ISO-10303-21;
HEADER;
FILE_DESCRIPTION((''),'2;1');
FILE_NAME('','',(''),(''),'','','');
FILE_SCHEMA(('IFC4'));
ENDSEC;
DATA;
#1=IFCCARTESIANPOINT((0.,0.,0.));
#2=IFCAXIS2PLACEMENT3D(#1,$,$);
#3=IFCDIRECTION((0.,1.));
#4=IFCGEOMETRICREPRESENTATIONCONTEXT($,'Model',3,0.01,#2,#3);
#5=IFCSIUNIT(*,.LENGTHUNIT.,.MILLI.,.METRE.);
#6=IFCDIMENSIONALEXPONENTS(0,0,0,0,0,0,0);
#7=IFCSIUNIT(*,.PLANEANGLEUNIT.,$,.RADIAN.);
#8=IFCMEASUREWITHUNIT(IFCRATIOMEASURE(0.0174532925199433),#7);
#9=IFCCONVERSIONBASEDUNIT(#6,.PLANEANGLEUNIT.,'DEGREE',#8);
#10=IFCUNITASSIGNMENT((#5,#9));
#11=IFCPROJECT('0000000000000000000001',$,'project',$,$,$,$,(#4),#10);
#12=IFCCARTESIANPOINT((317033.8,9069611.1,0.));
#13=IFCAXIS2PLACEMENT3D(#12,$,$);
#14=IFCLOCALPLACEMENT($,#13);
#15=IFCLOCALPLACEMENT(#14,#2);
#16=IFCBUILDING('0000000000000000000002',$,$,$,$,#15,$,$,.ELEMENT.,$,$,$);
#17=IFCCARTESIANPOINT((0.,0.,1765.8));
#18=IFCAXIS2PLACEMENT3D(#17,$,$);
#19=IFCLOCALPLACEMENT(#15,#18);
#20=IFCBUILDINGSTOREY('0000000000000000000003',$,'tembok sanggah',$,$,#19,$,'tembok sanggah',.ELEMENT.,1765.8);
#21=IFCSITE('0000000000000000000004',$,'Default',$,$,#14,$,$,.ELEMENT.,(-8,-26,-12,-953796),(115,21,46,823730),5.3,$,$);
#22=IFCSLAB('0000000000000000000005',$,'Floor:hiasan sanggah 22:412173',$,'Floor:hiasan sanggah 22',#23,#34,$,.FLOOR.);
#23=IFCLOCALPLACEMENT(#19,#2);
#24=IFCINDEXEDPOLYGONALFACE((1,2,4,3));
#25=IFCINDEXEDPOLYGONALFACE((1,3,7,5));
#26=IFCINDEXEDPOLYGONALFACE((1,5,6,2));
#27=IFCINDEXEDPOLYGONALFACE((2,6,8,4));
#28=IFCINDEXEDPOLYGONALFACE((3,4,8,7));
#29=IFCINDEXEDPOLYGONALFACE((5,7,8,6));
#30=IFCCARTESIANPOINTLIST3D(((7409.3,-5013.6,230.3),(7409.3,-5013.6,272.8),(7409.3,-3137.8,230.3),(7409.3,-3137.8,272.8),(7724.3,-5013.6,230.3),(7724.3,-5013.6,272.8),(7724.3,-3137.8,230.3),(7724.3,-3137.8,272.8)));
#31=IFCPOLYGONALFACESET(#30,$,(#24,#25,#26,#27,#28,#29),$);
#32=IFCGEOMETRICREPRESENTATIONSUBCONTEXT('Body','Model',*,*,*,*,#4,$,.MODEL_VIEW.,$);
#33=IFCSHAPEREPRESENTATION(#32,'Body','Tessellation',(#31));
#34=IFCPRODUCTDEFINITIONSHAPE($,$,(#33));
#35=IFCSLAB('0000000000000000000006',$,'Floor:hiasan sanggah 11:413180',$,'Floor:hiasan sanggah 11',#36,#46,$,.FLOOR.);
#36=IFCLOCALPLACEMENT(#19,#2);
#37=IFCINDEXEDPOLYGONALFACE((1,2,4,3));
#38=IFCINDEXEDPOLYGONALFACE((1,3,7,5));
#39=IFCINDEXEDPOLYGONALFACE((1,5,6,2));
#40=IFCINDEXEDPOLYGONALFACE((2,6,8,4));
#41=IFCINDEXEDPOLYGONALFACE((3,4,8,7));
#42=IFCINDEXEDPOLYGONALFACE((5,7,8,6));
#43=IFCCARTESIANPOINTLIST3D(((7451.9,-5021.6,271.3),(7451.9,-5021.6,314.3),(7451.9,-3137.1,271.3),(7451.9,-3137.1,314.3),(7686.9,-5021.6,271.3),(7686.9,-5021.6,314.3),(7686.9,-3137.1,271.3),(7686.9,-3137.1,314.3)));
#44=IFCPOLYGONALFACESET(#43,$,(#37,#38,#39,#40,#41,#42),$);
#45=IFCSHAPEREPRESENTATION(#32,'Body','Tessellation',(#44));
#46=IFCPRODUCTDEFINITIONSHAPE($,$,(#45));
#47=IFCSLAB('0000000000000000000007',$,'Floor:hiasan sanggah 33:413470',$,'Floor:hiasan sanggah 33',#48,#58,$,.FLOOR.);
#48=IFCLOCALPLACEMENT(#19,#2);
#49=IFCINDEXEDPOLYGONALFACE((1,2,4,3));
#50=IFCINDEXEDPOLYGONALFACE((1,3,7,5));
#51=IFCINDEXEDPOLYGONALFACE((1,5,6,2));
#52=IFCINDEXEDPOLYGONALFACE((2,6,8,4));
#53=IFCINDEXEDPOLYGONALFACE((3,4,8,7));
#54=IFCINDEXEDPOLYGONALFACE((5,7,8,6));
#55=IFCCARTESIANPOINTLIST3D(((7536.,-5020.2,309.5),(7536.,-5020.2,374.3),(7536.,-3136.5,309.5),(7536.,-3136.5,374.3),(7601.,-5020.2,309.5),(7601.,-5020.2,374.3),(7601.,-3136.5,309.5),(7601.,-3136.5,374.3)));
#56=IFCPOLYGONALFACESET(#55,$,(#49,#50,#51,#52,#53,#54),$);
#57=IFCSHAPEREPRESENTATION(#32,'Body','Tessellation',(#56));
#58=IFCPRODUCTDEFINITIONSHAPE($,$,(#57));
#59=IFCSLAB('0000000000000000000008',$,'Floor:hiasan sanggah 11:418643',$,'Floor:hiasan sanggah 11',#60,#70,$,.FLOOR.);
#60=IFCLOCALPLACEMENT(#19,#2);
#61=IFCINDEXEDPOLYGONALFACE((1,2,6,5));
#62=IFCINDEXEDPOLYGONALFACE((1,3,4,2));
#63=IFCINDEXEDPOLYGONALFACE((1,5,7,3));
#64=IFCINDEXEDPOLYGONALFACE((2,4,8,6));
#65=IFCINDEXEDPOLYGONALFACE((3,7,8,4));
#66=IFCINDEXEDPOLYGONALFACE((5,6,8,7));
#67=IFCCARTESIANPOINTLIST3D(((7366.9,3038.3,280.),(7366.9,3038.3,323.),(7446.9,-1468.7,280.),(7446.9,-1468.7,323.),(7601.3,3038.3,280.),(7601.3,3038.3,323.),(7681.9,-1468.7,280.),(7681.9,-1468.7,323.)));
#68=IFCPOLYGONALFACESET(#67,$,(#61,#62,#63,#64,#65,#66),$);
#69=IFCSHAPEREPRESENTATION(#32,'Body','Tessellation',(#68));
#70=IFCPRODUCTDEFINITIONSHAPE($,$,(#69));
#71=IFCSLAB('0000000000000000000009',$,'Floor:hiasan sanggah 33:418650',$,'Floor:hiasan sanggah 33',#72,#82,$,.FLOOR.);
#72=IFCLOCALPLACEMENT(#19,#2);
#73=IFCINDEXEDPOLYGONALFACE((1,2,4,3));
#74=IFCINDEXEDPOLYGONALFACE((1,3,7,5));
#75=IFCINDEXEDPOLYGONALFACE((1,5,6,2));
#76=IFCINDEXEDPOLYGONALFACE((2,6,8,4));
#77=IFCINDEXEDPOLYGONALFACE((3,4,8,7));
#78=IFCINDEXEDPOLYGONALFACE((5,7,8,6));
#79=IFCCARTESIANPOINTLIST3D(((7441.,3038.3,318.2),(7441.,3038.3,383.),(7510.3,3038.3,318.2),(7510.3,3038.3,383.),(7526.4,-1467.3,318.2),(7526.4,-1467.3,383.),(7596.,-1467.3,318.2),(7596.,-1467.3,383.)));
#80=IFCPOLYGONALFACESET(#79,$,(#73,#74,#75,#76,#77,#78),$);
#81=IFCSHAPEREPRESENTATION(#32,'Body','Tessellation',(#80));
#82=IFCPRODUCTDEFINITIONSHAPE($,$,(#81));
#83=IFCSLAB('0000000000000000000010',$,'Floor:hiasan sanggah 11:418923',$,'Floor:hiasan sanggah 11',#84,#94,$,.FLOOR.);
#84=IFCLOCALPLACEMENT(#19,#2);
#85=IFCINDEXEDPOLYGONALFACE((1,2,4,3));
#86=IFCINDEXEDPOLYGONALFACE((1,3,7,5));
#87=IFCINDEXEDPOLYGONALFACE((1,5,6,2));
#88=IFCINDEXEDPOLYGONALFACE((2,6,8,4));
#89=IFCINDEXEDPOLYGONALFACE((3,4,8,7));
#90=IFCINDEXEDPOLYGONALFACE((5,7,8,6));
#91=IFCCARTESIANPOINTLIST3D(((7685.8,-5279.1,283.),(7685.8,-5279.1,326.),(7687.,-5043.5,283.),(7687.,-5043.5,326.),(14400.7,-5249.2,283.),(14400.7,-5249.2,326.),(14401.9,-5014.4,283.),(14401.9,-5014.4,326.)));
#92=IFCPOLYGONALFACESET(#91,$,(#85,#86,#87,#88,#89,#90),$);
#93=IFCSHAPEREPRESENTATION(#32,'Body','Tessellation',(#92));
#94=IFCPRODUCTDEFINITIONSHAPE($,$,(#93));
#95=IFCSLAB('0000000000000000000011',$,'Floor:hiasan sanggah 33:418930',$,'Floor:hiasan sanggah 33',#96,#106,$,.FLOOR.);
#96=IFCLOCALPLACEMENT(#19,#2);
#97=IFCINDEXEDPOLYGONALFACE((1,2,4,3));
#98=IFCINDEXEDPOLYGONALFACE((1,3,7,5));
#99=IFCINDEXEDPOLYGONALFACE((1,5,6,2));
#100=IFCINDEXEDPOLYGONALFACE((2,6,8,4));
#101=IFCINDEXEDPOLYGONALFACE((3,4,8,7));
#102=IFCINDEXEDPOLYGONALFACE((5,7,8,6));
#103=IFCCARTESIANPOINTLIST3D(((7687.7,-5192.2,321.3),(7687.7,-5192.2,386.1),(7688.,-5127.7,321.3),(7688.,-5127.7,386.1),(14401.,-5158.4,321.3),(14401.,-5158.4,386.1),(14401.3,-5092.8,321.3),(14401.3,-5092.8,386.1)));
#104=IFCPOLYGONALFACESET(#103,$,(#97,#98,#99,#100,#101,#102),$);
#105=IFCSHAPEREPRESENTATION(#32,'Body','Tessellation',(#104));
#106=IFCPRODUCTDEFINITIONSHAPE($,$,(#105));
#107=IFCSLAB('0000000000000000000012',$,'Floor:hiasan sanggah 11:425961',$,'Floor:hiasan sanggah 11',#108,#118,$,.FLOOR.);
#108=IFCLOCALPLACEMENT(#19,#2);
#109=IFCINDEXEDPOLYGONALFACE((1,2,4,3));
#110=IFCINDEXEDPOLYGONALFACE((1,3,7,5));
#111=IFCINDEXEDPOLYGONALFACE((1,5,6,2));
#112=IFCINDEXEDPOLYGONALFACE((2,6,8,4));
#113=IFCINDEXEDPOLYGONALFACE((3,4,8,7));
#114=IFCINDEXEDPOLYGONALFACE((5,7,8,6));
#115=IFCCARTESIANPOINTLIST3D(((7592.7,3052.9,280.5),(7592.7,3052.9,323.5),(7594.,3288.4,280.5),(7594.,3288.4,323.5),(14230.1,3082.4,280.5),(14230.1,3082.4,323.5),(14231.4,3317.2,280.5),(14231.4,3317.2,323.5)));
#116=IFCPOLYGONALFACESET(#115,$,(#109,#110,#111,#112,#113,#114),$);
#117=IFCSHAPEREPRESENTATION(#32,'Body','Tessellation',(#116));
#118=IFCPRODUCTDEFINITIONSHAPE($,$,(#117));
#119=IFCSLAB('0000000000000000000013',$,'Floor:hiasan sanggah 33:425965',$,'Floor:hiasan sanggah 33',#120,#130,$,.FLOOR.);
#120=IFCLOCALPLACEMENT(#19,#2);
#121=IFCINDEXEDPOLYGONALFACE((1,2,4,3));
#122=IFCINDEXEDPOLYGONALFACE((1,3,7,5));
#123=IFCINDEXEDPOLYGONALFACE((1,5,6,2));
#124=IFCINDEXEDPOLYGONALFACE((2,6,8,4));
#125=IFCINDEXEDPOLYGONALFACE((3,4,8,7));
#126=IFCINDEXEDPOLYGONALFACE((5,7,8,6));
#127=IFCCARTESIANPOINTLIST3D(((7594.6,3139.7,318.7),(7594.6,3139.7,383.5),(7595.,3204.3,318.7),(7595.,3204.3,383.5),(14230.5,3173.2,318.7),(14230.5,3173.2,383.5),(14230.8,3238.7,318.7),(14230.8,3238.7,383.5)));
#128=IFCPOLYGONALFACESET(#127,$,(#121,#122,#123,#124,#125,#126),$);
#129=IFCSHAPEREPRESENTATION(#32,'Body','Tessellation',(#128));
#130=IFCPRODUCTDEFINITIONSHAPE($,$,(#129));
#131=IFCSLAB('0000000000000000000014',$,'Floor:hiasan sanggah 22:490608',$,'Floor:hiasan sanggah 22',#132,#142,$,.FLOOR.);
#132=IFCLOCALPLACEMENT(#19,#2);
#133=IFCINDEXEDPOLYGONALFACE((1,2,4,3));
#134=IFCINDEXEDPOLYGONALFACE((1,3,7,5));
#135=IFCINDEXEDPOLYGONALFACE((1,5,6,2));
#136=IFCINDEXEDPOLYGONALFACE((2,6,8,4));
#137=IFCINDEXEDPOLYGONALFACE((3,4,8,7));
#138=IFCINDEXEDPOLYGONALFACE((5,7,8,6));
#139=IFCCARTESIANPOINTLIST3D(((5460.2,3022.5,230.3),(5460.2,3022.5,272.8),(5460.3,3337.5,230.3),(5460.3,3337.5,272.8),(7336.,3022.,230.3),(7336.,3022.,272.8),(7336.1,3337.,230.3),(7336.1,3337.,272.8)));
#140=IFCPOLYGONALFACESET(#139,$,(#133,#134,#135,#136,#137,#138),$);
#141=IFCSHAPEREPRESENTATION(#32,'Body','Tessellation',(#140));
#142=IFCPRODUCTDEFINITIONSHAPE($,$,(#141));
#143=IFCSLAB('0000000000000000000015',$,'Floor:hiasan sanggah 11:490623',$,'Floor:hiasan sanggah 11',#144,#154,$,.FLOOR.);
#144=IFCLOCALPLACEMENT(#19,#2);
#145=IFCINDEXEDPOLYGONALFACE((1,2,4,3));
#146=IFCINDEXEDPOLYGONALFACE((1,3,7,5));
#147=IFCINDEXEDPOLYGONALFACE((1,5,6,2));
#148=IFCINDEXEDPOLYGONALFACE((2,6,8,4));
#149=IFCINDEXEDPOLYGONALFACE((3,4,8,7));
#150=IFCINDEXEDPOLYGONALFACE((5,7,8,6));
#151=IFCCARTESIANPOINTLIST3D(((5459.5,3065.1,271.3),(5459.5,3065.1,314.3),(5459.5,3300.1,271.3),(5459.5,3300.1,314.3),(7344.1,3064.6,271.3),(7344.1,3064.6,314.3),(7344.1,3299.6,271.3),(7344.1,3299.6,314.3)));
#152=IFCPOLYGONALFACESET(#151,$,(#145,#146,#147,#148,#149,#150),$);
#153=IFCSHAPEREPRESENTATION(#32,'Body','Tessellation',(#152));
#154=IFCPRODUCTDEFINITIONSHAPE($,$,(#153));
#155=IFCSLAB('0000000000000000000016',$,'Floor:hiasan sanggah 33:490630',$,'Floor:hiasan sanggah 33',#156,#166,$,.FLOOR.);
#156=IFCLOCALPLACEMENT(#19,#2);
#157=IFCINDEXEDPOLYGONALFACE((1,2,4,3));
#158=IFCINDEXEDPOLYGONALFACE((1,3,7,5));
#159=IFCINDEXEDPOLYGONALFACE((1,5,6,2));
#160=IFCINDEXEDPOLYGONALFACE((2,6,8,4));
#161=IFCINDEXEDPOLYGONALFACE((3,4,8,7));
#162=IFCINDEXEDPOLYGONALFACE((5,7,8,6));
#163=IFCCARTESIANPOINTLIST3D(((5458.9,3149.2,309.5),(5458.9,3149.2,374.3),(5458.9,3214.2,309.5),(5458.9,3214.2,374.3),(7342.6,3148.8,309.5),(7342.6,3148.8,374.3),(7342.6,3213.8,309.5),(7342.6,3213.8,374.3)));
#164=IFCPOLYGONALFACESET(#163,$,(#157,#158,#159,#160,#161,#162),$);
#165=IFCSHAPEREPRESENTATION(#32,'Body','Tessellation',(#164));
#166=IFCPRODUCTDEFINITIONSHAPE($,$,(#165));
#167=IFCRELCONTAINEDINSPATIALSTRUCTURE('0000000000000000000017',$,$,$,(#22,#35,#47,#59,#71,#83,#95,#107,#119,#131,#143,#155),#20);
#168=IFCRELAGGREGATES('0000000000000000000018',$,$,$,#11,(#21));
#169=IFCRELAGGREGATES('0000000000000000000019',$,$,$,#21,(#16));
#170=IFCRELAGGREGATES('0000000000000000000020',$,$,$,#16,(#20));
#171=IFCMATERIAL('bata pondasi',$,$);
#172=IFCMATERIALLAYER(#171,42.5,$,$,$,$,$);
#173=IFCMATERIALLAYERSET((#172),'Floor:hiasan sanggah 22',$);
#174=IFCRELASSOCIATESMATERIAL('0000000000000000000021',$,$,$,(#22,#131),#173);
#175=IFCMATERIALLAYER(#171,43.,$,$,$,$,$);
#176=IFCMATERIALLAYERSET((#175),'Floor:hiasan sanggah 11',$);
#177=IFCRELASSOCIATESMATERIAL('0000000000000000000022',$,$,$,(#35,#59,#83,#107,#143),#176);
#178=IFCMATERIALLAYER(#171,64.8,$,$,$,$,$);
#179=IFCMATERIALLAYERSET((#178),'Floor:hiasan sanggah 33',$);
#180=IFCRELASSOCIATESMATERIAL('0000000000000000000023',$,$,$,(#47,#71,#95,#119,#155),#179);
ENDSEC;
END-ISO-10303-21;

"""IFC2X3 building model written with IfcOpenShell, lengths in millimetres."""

from ifc_helpers import new_model, entity, si_unit, converted_unit, direction, frame, frame_2d, origin, origin_2d_with_axis, place, context, subcontext, project, spatial, polyline, rectangle, outline, extrude, material, layer, layer_set, layer_usage, element, save


model = new_model("IFC2X3")

# Units and contexts
model_context = context("Model", 3, precision=0.01, world=origin(), true_north=direction((0.0, 1.0)))
body_context = subcontext(model_context, "Body", "Model", "MODEL_VIEW")
ifc_project = project(units=[si_unit("LENGTHUNIT", "METRE", prefix="MILLI"), converted_unit("PLANEANGLEUNIT", "DEGREE", entity("IfcRatioMeasure", 0.0174532925199433), si_unit("PLANEANGLEUNIT", "RADIAN"), dimensions=[0, 0, 0, 0, 0, 0, 0])], contexts=[model_context])

# Site, building, storey
site_placement = place(None, frame((317033.8, 9069611.1, 0.0)))
site = spatial("IfcSite", under=ifc_project, at=site_placement, Name="Default", CompositionType="ELEMENT", RefLatitude=(-8, -26, -12, -953796), RefLongitude=(115, 21, 46, 823730), RefElevation=5.3)
building_placement = place(site_placement, origin())
building = spatial("IfcBuilding", under=site, at=building_placement, CompositionType="ELEMENT")
storey_placement = place(building_placement, frame((0.0, 0.0, 1765.8)))
storey = spatial("IfcBuildingStorey", under=building, at=storey_placement, Name="tembok sanggah", LongName="tembok sanggah", CompositionType="ELEMENT", Elevation=1765.8)

# Slabs
ifc_material = material(Name="bata pondasi")
ifc_layer_1 = layer(ifc_material, 42.5)
ifc_layer_set_1 = layer_set([ifc_layer_1], Name="Floor:hiasan sanggah 22")
ifc_layer_usage_1 = layer_usage(ifc_layer_set_1, "AXIS3", "POSITIVE", 0.0)
slab_1_placement = place(storey_placement, origin())
element("IfcSlab", 1, at=slab_1_placement, inside=storey, material=ifc_layer_usage_1, Name="Floor:hiasan sanggah 22:412173", ObjectType="Floor:hiasan sanggah 22", PredefinedType="FLOOR", context=body_context, shape_type="SweptSolid", body=[
    extrude(rectangle(XDim=1875.8, YDim=315.0, at=frame_2d((0.0, 0.0), x_axis=(1.0, 0.0))), frame((7566.8, -4075.7, 272.8), z_axis=(0.0, 0.0, -1.0), x_axis=(0.0, 1.0, 0.0)), (0.0, 0.0, 1.0), 42.5),
])
ifc_layer_2 = layer(ifc_material, 43.0)
ifc_layer_set_2 = layer_set([ifc_layer_2], Name="Floor:hiasan sanggah 11")
ifc_layer_usage_2 = layer_usage(ifc_layer_set_2, "AXIS3", "POSITIVE", 0.0)
slab_2_placement = place(storey_placement, origin())
element("IfcSlab", 2, at=slab_2_placement, inside=storey, material=ifc_layer_usage_2, Name="Floor:hiasan sanggah 11:413180", ObjectType="Floor:hiasan sanggah 11", PredefinedType="FLOOR", context=body_context, shape_type="SweptSolid", body=[
    extrude(rectangle(XDim=1884.6, YDim=235.0, at=frame_2d((0.0, 0.0), x_axis=(1.0, 0.0))), frame((7569.4, -4079.3, 314.3), z_axis=(0.0, 0.0, -1.0), x_axis=(0.0, 1.0, 0.0)), (0.0, 0.0, 1.0), 43.0),
])
ifc_layer_3 = layer(ifc_material, 64.8)
ifc_layer_set_3 = layer_set([ifc_layer_3], Name="Floor:hiasan sanggah 33")
ifc_layer_usage_3 = layer_usage(ifc_layer_set_3, "AXIS3", "POSITIVE", 0.0)
slab_3_placement = place(storey_placement, origin())
element("IfcSlab", 3, at=slab_3_placement, inside=storey, material=ifc_layer_usage_3, Name="Floor:hiasan sanggah 33:413470", ObjectType="Floor:hiasan sanggah 33", PredefinedType="FLOOR", context=body_context, shape_type="SweptSolid", body=[
    extrude(rectangle(XDim=1883.7, YDim=65.0, at=frame_2d((0.0, 0.0), x_axis=(1.0, 0.0))), frame((7568.5, -4078.3, 374.3), z_axis=(0.0, 0.0, -1.0), x_axis=(0.0, 1.0, 0.0)), (0.0, 0.0, 1.0), 64.8),
])
ifc_layer_usage_4 = layer_usage(ifc_layer_set_2, "AXIS3", "POSITIVE", 0.0)
slab_4_placement = place(storey_placement, origin())
element("IfcSlab", 4, at=slab_4_placement, inside=storey, material=ifc_layer_usage_4, Name="Floor:hiasan sanggah 11:418643", ObjectType="Floor:hiasan sanggah 11", PredefinedType="FLOOR", context=body_context, shape_type="SweptSolid", body=[
    extrude(outline(polyline([(-157.7, -2253.5), (77.4, -2253.5), (157.3, 2253.5), (-77.0, 2253.5), (-157.7, -2253.5)])), frame((7524.3, 784.8, 323.0), z_axis=(0.0, 0.0, -1.0), x_axis=(-1.0, 0.0, 0.0)), (0.0, 0.0, 1.0), 43.0),
])
ifc_layer_usage_5 = layer_usage(ifc_layer_set_3, "AXIS3", "POSITIVE", 0.0)
slab_5_placement = place(storey_placement, origin())
element("IfcSlab", 5, at=slab_5_placement, inside=storey, material=ifc_layer_usage_5, Name="Floor:hiasan sanggah 33:418650", ObjectType="Floor:hiasan sanggah 33", PredefinedType="FLOOR", context=body_context, shape_type="SweptSolid", body=[
    extrude(outline(polyline([(-77.6, -2252.8), (-7.9, -2252.8), (77.4, 2252.8), (8.2, 2252.8), (-77.6, -2252.8)])), frame((7518.4, 785.5, 383.0), z_axis=(0.0, 0.0, -1.0), x_axis=(-1.0, 0.0, 0.0)), (0.0, 0.0, 1.0), 64.8),
])
ifc_layer_usage_6 = layer_usage(ifc_layer_set_2, "AXIS3", "POSITIVE", 0.0)
slab_6_placement = place(storey_placement, origin())
element("IfcSlab", 6, at=slab_6_placement, inside=storey, material=ifc_layer_usage_6, Name="Floor:hiasan sanggah 11:418923", ObjectType="Floor:hiasan sanggah 11", PredefinedType="FLOOR", context=body_context, shape_type="SweptSolid", body=[
    extrude(outline(polyline([(-3356.3, -117.6), (3358.6, -117.6), (3356.4, 117.2), (-3358.6, 117.9), (-3356.3, -117.6)])), frame((11043.8, -5146.6, 326.0), z_axis=(0.0, 0.0, -1.0), x_axis=(0.999991, 0.004339, 0.0)), (0.0, 0.0, 1.0), 43.0),
])
ifc_layer_usage_7 = layer_usage(ifc_layer_set_3, "AXIS3", "POSITIVE", 0.0)
slab_7_placement = place(storey_placement, origin())
element("IfcSlab", 7, at=slab_7_placement, inside=storey, material=ifc_layer_usage_7, Name="Floor:hiasan sanggah 33:418930", ObjectType="Floor:hiasan sanggah 33", PredefinedType="FLOOR", context=body_context, shape_type="SweptSolid", body=[
    extrude(outline(polyline([(-3356.4, -32.5), (3357.0, -32.5), (3356.4, 33.0), (-3357.0, 32.0), (-3356.4, -32.5)])), frame((11044.5, -5142.8, 386.1), z_axis=(0.0, 0.0, -1.0), x_axis=(0.999987, 0.005194, 0.0)), (0.0, 0.0, 1.0), 64.8),
])
ifc_layer_usage_8 = layer_usage(ifc_layer_set_2, "AXIS3", "POSITIVE", 0.0)
slab_8_placement = place(storey_placement, origin())
element("IfcSlab", 8, at=slab_8_placement, inside=storey, material=ifc_layer_usage_8, Name="Floor:hiasan sanggah 11:425961", ObjectType="Floor:hiasan sanggah 11", PredefinedType="FLOOR", context=body_context, shape_type="SweptSolid", body=[
    extrude(outline(polyline([(-3317.6, -117.6), (3319.9, -117.6), (3317.6, 117.2), (-3319.9, 117.9), (-3317.6, -117.6)])), frame((10912.1, 3185.2, 323.5), z_axis=(0.0, 0.0, -1.0), x_axis=(0.999991, 0.004339, 0.0)), (0.0, 0.0, 1.0), 43.0),
])
ifc_layer_usage_9 = layer_usage(ifc_layer_set_3, "AXIS3", "POSITIVE", 0.0)
slab_9_placement = place(storey_placement, origin())
element("IfcSlab", 9, at=slab_9_placement, inside=storey, material=ifc_layer_usage_9, Name="Floor:hiasan sanggah 33:425965", ObjectType="Floor:hiasan sanggah 33", PredefinedType="FLOOR", context=body_context, shape_type="SweptSolid", body=[
    extrude(outline(polyline([(-3317.6, -32.5), (3318.3, -32.5), (3317.6, 33.0), (-3318.3, 32.0), (-3317.6, -32.5)])), frame((10912.7, 3189.0, 383.5), z_axis=(0.0, 0.0, -1.0), x_axis=(0.999987, 0.005194, 0.0)), (0.0, 0.0, 1.0), 64.8),
])
ifc_layer_usage_10 = layer_usage(ifc_layer_set_1, "AXIS3", "POSITIVE", 0.0)
slab_10_placement = place(storey_placement, origin())
element("IfcSlab", 10, at=slab_10_placement, inside=storey, material=ifc_layer_usage_10, Name="Floor:hiasan sanggah 22:490608", ObjectType="Floor:hiasan sanggah 22", PredefinedType="FLOOR", context=body_context, shape_type="SweptSolid", body=[
    extrude(rectangle(XDim=1875.8, YDim=315.0, at=frame_2d((0.0, 0.0), x_axis=(1.0, 0.0))), frame((6398.2, 3179.7, 272.8), z_axis=(0.0, 0.0, -1.0), x_axis=(1.0, -0.000224, 0.0)), (0.0, 0.0, 1.0), 42.5),
])
ifc_layer_usage_11 = layer_usage(ifc_layer_set_2, "AXIS3", "POSITIVE", 0.0)
slab_11_placement = place(storey_placement, origin())
element("IfcSlab", 11, at=slab_11_placement, inside=storey, material=ifc_layer_usage_11, Name="Floor:hiasan sanggah 11:490623", ObjectType="Floor:hiasan sanggah 11", PredefinedType="FLOOR", context=body_context, shape_type="SweptSolid", body=[
    extrude(rectangle(XDim=1884.6, YDim=235.0, at=frame_2d((0.0, 0.0), x_axis=(1.0, 0.0))), frame((6401.8, 3182.4, 314.3), z_axis=(0.0, 0.0, -1.0), x_axis=(1.0, -0.000224, 0.0)), (0.0, 0.0, 1.0), 43.0),
])
ifc_layer_usage_12 = layer_usage(ifc_layer_set_3, "AXIS3", "POSITIVE", 0.0)
slab_12_placement = place(storey_placement, origin())
element("IfcSlab", 12, at=slab_12_placement, inside=storey, material=ifc_layer_usage_12, Name="Floor:hiasan sanggah 33:490630", ObjectType="Floor:hiasan sanggah 33", PredefinedType="FLOOR", context=body_context, shape_type="SweptSolid", body=[
    extrude(rectangle(XDim=1883.7, YDim=65.0, at=origin_2d_with_axis()), frame((6400.8, 3181.5, 374.3), z_axis=(0.0, 0.0, -1.0), x_axis=(1.0, -0.000224, 0.0)), (0.0, 0.0, 1.0), 64.8),
])

save(model, "model.ifc")
